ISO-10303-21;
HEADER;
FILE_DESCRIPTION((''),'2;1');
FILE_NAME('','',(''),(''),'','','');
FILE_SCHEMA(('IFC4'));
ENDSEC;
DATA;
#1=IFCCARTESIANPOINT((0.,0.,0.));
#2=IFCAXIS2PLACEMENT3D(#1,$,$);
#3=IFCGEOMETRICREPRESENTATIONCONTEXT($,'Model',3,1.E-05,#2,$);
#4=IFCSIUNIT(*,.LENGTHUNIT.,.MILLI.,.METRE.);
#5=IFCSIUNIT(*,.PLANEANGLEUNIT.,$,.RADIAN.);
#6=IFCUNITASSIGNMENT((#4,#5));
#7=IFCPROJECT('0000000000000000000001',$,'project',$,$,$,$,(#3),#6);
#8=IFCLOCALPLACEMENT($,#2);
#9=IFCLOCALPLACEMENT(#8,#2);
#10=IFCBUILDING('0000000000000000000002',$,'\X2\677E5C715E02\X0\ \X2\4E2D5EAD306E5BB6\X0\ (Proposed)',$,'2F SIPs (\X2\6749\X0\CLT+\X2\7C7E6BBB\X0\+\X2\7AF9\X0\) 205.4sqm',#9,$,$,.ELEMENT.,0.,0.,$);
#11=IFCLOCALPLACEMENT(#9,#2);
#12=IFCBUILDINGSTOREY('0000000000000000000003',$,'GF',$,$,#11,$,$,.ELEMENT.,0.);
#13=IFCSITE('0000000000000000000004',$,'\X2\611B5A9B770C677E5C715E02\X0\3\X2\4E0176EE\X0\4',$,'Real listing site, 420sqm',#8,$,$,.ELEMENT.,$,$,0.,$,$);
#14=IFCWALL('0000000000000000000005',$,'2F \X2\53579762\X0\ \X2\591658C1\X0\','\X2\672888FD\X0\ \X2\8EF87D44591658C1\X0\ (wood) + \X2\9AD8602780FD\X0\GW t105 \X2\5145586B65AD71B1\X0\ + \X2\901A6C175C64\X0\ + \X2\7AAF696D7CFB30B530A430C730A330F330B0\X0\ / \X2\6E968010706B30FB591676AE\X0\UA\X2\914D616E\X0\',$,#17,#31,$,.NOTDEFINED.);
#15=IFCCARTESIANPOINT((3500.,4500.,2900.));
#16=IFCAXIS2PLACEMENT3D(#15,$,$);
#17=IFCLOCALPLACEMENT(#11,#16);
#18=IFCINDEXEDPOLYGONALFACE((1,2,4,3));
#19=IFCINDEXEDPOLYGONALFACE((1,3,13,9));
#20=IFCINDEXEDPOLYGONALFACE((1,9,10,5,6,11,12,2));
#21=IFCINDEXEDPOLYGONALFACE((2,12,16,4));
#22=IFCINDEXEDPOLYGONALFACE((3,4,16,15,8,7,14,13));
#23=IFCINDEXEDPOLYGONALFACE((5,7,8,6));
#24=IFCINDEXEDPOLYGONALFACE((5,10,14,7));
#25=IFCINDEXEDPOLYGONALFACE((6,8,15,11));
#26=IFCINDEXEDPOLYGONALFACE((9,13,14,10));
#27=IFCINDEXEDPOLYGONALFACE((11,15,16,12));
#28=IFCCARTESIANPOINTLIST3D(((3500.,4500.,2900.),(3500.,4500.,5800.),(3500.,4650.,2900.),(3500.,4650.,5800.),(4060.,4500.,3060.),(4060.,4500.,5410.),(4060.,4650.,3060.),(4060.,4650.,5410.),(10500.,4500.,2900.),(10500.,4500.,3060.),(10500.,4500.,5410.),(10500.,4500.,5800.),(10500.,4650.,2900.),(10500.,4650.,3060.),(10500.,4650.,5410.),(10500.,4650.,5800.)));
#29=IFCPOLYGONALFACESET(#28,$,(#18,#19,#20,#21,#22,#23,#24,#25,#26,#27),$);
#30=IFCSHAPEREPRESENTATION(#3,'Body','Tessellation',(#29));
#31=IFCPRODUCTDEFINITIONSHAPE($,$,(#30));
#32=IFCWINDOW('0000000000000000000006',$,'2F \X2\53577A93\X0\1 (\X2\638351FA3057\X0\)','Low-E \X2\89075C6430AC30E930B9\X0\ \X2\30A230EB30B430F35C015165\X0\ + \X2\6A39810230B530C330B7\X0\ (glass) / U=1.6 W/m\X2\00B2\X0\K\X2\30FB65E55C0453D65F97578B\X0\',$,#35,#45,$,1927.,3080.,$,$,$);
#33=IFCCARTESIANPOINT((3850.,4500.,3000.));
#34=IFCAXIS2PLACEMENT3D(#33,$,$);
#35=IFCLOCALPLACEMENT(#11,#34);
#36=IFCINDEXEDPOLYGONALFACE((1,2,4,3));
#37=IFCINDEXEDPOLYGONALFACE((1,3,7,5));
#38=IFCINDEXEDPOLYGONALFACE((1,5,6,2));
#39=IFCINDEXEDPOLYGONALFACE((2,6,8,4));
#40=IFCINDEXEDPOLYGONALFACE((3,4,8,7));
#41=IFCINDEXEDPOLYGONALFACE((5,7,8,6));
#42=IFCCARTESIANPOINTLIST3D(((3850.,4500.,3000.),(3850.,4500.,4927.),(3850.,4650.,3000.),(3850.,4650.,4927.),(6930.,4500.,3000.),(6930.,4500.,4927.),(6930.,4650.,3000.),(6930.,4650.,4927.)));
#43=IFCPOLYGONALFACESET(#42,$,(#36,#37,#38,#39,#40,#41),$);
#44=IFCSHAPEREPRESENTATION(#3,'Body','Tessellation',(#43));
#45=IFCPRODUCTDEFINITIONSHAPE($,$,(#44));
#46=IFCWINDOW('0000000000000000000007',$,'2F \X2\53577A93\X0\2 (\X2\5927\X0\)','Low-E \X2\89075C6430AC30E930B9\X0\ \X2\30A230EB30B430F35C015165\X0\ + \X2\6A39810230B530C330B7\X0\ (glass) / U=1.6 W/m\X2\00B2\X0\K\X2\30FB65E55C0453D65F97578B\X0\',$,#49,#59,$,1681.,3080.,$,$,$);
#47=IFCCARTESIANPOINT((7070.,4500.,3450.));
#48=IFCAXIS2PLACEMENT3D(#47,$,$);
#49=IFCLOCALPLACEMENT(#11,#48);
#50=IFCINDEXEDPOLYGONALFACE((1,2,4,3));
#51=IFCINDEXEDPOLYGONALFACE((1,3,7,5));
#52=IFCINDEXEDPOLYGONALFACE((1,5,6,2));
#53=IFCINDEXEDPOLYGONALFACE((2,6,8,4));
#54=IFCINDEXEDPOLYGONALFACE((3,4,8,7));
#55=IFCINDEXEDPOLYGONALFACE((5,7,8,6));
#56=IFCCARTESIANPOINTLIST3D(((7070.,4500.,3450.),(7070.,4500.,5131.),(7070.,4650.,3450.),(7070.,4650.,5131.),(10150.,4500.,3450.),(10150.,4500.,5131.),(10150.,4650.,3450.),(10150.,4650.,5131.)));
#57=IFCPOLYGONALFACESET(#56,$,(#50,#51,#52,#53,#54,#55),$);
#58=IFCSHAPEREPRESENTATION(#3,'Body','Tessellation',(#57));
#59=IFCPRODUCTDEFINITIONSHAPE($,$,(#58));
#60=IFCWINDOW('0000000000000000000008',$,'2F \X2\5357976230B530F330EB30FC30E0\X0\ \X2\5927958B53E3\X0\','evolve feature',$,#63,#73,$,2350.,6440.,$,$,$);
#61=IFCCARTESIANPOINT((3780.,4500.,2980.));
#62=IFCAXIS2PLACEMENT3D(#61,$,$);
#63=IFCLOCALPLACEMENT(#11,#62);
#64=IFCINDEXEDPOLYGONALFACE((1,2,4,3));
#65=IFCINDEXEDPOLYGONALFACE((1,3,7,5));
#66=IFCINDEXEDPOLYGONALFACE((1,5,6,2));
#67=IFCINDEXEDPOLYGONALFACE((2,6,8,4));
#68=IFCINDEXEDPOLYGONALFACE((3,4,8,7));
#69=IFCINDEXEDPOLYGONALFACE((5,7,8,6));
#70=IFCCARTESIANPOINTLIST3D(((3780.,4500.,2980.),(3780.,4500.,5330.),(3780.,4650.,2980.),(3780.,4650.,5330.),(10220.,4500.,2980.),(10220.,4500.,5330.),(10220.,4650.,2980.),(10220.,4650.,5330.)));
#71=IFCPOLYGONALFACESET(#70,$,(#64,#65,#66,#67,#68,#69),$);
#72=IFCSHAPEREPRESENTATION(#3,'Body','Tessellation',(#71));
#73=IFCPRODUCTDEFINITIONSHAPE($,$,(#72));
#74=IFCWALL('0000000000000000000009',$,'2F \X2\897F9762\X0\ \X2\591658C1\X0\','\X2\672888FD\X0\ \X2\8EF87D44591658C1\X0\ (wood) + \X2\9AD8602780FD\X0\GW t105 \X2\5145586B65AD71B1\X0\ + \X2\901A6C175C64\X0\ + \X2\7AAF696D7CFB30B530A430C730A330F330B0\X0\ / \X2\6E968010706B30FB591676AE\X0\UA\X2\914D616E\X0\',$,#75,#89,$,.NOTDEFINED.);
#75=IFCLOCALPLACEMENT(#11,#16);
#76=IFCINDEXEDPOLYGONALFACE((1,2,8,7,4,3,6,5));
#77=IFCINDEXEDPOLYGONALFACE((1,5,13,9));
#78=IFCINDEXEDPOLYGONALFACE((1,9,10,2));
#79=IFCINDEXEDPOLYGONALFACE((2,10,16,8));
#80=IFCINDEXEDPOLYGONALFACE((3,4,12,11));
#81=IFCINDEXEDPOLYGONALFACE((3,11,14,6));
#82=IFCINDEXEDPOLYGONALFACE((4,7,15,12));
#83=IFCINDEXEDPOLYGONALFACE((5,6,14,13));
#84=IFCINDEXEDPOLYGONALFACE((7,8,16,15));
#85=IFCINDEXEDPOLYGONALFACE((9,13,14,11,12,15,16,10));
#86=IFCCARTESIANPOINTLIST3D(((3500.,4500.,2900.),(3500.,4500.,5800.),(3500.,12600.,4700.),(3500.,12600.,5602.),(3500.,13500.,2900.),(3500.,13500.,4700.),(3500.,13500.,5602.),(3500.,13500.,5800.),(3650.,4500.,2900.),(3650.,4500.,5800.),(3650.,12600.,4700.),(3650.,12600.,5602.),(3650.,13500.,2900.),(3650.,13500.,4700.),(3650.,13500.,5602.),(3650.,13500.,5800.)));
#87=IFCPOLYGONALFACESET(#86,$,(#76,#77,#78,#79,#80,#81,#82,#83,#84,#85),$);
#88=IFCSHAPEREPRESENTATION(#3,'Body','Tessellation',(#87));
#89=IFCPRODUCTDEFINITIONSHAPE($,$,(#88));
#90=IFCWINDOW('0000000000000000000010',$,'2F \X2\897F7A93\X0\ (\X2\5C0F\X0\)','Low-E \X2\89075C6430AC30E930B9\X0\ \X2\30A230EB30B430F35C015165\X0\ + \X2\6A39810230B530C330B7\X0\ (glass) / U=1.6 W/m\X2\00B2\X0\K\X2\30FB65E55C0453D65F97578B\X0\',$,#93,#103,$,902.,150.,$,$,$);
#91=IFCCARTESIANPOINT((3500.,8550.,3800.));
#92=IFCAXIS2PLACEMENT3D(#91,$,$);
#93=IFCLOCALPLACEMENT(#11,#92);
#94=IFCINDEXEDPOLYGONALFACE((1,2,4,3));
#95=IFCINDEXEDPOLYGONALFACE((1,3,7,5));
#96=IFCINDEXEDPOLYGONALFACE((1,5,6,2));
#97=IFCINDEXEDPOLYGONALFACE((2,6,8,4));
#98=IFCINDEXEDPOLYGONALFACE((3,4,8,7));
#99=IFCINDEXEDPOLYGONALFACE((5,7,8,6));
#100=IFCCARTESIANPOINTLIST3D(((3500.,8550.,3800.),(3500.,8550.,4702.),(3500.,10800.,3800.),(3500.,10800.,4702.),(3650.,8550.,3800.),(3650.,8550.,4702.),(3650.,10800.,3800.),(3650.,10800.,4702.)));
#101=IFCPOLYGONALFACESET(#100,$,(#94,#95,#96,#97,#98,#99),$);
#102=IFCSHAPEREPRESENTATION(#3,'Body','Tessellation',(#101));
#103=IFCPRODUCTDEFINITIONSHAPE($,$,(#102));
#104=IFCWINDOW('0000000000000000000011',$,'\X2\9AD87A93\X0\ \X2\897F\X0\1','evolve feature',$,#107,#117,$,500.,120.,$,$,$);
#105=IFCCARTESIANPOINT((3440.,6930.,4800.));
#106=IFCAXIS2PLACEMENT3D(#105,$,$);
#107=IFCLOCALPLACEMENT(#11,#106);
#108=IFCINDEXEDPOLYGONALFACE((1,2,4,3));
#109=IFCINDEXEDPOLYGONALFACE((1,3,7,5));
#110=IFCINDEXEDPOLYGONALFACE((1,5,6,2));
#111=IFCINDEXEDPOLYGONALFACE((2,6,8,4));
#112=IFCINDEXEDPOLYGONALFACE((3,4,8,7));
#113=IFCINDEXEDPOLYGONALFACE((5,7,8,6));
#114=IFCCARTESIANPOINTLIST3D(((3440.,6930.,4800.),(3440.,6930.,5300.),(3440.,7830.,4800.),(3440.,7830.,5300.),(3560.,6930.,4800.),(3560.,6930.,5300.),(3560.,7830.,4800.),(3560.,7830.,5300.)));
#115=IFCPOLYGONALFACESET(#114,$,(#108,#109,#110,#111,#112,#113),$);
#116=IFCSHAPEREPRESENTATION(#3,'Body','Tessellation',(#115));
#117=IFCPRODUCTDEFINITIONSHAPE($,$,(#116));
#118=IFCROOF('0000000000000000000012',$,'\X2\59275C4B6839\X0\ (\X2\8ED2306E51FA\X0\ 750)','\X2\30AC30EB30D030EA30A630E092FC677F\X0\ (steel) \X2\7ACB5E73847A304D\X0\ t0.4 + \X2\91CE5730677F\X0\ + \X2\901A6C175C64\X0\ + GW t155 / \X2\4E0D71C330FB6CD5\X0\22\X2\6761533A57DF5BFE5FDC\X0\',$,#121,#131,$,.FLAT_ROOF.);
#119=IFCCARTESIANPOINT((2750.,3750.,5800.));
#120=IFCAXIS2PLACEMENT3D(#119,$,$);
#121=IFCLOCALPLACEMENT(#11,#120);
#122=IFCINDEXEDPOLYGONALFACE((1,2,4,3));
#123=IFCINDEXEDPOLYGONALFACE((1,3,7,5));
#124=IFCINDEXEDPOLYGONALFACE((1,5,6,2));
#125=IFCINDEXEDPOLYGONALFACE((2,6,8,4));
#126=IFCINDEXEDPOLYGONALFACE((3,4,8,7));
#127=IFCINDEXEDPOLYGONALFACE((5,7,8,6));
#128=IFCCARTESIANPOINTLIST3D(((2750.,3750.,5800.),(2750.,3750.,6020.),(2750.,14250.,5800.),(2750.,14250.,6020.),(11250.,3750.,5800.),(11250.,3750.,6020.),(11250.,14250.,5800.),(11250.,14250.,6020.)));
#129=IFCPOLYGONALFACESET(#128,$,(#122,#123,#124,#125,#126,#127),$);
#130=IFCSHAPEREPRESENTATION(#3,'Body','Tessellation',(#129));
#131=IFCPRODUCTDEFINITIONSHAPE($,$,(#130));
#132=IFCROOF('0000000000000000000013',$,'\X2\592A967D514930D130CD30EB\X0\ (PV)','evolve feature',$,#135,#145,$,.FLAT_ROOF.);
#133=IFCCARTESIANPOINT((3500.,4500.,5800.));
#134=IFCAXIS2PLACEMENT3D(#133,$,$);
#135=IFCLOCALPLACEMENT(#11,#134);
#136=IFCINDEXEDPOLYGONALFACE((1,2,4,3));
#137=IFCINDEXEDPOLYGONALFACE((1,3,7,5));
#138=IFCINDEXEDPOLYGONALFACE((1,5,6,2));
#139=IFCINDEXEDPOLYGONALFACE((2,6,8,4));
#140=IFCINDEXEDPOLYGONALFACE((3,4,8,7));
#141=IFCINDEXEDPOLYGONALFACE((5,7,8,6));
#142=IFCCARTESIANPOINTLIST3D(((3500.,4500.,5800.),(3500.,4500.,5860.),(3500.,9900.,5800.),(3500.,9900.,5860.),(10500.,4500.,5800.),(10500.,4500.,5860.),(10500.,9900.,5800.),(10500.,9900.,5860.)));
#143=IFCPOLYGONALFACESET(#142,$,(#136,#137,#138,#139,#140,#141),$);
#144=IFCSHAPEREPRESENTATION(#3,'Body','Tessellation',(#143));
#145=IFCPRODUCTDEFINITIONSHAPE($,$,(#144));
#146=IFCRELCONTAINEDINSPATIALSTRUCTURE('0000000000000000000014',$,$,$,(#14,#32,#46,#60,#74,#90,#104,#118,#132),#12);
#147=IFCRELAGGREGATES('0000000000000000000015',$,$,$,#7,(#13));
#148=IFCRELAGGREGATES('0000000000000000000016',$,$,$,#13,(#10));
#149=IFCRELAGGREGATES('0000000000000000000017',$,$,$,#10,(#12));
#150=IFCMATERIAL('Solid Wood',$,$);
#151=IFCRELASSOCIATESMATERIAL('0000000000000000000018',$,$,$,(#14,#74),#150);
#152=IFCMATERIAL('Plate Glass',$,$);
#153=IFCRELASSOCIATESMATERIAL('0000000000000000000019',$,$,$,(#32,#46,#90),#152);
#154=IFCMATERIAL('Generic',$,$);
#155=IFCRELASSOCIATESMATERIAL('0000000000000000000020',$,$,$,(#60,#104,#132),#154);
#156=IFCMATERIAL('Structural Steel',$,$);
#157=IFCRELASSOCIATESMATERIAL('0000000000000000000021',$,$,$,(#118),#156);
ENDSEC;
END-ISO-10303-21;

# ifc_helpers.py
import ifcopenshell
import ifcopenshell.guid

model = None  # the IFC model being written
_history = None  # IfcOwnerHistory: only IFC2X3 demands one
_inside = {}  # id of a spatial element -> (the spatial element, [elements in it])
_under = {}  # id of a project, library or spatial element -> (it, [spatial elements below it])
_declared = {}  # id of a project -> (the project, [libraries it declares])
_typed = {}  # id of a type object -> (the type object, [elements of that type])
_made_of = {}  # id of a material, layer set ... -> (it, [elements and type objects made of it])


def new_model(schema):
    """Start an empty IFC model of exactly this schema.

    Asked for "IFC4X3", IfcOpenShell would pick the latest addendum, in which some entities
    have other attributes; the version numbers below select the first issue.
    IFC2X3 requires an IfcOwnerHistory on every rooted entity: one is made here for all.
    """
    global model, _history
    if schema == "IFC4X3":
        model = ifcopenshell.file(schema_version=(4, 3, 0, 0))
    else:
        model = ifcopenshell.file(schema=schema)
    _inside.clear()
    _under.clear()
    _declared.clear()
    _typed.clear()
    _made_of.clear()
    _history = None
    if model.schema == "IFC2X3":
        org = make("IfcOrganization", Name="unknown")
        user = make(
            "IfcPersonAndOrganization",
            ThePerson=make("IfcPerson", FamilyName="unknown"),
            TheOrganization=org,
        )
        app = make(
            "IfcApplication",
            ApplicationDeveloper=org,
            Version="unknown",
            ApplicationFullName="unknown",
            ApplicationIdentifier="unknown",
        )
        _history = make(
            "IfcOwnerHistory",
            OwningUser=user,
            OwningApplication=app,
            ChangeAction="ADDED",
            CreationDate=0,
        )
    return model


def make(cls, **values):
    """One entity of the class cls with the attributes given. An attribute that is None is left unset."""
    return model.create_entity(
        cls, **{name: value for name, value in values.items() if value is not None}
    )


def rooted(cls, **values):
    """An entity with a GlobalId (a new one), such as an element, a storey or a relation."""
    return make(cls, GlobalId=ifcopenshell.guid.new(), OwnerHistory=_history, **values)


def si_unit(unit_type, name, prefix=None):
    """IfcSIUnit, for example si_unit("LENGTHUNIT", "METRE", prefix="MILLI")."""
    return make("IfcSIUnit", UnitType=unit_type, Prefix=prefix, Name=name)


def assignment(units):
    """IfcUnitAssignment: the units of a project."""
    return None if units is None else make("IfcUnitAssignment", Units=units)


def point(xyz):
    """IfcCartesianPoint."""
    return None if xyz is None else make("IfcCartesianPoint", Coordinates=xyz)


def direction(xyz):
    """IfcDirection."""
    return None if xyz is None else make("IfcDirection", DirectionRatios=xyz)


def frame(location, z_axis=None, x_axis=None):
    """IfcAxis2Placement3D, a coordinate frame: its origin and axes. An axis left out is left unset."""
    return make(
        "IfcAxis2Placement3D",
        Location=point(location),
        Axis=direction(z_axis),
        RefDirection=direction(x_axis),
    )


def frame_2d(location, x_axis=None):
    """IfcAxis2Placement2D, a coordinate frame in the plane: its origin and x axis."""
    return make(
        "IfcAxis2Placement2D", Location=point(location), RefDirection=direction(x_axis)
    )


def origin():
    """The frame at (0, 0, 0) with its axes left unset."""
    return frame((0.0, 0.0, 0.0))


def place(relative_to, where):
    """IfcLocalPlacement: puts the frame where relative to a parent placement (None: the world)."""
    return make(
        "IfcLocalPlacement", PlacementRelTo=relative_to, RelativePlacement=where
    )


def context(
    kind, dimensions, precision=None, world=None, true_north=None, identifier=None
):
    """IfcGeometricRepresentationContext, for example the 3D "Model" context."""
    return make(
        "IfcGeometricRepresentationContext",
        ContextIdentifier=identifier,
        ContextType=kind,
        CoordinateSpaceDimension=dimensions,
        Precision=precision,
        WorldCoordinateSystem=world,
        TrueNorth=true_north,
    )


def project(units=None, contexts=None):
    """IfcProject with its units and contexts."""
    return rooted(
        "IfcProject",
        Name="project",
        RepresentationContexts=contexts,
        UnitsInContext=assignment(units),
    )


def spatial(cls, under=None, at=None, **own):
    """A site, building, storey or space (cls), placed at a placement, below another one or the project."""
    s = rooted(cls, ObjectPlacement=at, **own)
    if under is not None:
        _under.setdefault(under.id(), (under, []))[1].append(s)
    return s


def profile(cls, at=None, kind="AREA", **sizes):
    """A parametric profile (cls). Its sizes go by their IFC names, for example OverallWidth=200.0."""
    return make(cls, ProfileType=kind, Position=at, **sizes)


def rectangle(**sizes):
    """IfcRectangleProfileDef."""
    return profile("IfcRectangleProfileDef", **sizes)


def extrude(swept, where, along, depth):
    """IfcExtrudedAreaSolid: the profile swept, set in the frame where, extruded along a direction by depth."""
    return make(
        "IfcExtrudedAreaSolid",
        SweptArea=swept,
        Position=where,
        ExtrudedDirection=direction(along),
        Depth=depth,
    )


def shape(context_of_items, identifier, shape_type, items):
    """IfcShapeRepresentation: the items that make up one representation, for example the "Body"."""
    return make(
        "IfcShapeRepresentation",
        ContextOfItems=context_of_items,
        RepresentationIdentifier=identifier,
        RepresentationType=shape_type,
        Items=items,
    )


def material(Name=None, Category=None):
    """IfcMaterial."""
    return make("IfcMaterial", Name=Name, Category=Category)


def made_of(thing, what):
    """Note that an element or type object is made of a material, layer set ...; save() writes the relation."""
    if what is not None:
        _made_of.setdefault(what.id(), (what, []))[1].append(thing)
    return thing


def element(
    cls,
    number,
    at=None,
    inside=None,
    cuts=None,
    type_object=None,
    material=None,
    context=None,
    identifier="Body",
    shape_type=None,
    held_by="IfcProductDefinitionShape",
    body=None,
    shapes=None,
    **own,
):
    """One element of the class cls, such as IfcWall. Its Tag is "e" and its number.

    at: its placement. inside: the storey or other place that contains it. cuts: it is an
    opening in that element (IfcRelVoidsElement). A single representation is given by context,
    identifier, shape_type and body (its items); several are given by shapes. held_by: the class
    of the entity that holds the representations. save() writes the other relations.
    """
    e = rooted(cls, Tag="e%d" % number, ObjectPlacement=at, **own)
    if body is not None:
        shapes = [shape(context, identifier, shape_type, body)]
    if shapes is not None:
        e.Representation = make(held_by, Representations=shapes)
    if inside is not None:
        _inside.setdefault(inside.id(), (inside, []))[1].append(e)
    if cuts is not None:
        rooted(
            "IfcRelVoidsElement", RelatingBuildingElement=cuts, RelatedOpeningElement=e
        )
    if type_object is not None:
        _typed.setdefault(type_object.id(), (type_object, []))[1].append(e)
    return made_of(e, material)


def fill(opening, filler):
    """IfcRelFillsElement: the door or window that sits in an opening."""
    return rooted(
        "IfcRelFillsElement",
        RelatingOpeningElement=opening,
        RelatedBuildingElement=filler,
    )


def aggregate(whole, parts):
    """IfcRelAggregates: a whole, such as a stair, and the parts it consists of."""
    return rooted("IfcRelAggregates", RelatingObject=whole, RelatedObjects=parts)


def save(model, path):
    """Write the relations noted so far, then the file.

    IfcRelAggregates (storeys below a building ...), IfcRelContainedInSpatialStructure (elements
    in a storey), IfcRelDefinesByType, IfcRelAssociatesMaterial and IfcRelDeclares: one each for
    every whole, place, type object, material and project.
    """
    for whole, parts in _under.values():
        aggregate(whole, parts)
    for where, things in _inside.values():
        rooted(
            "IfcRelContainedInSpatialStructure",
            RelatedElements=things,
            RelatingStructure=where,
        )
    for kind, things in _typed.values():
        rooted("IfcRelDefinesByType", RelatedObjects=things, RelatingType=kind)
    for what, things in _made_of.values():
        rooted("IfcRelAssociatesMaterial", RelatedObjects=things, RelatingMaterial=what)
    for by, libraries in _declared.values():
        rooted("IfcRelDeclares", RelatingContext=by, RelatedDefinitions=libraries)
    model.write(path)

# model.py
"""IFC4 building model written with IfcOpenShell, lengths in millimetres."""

from ifc_helpers import new_model, si_unit, frame, frame_2d, origin, place, context, project, spatial, rectangle, extrude, material, element, fill, save


model = new_model("IFC4")

# Units and contexts
model_context = context("Model", 3, precision=1e-05, world=origin())
ifc_project = project(units=[si_unit("LENGTHUNIT", "METRE", prefix="MILLI"), si_unit("PLANEANGLEUNIT", "RADIAN")], contexts=[model_context])

# Site, building, storey
site_placement = place(None, origin())
site = spatial("IfcSite", under=ifc_project, at=site_placement, Name="愛媛県松山市3丁目4", ObjectType="Real listing site, 420sqm", CompositionType="ELEMENT", RefElevation=0.0)
building_placement = place(site_placement, origin())
building = spatial("IfcBuilding", under=site, at=building_placement, Name="松山市 中庭の家 (Proposed)", ObjectType="2F SIPs (杉CLT+籾殻+竹) 205.4sqm", CompositionType="ELEMENT", ElevationOfRefHeight=0.0, ElevationOfTerrain=0.0)
storey_placement = place(building_placement, origin())
storey = spatial("IfcBuildingStorey", under=building, at=storey_placement, Name="GF", CompositionType="ELEMENT", Elevation=0.0)

# Shared definitions
ifc_material_1 = material(Name="Solid Wood")
ifc_material_2 = material(Name="Generic")

# Shared definitions
ifc_material_3 = material(Name="Plate Glass")

# Walls, openings, windows
wall_1_placement = place(storey_placement, frame((3500.0, 4500.0, 2900.0)))
wall_1 = element("IfcWall", 1, at=wall_1_placement, inside=storey, material=ifc_material_1, Name="2F 南面 外壁", Description="木製 軸組外壁 (wood) + 高性能GW t105 充填断熱 + 通気層 + 窯業系サイディング / 準耐火・外皮UA配慮", PredefinedType="NOTDEFINED", context=model_context, shape_type="SweptSolid", body=[
    extrude(rectangle(XDim=7000.0, YDim=150.0, at=frame_2d((3500.0, 75.0))), frame((3500.0, 4500.0, 2900.0)), (0.0, 0.0, 1.0), 2900.0),
])
opening_1_placement = place(storey_placement, frame((3850.0, 4500.0, 3000.0)))
opening_1 = element("IfcOpeningElement", 2, at=opening_1_placement, cuts=wall_1, PredefinedType="NOTDEFINED", context=model_context, shape_type="SweptSolid", body=[
    extrude(rectangle(XDim=3080.0, YDim=150.0, at=frame_2d((1540.0, 75.0))), frame((3850.0, 4500.0, 3000.0)), (0.0, 0.0, 1.0), 1927.0),
])
opening_2_placement = place(storey_placement, frame((7070.0, 4500.0, 3450.0)))
opening_2 = element("IfcOpeningElement", 3, at=opening_2_placement, cuts=wall_1, PredefinedType="NOTDEFINED", context=model_context, shape_type="SweptSolid", body=[
    extrude(rectangle(XDim=3080.0, YDim=150.0, at=frame_2d((1540.0, 75.0))), frame((7070.0, 4500.0, 3450.0)), (0.0, 0.0, 1.0), 1681.0),
])
opening_3_placement = place(storey_placement, frame((3780.0, 4500.0, 2980.0)))
opening_3 = element("IfcOpeningElement", 4, at=opening_3_placement, cuts=wall_1, PredefinedType="NOTDEFINED", context=model_context, shape_type="SweptSolid", body=[
    extrude(rectangle(XDim=6440.0, YDim=150.0, at=frame_2d((3220.0, 75.0))), frame((3780.0, 4500.0, 2980.0)), (0.0, 0.0, 1.0), 2350.0),
])
window_1_placement = place(storey_placement, frame((3850.0, 4500.0, 3000.0)))
window_1 = element("IfcWindow", 5, at=window_1_placement, inside=storey, material=ifc_material_3, Name="2F 南窓1 (掃出し)", Description="Low-E 複層ガラス アルゴン封入 + 樹脂サッシ (glass) / U=1.6 W/m²K・日射取得型", OverallHeight=1927.0, OverallWidth=3080.0, context=model_context, shape_type="SweptSolid", body=[
    extrude(rectangle(XDim=3080.0, YDim=150.0, at=frame_2d((1540.0, 75.0))), frame((3850.0, 4500.0, 3000.0)), (0.0, 0.0, 1.0), 1927.0),
])
fill(opening_1, window_1)
window_2_placement = place(storey_placement, frame((7070.0, 4500.0, 3450.0)))
window_2 = element("IfcWindow", 6, at=window_2_placement, inside=storey, material=ifc_material_3, Name="2F 南窓2 (大)", Description="Low-E 複層ガラス アルゴン封入 + 樹脂サッシ (glass) / U=1.6 W/m²K・日射取得型", OverallHeight=1681.0, OverallWidth=3080.0, context=model_context, shape_type="SweptSolid", body=[
    extrude(rectangle(XDim=3080.0, YDim=150.0, at=frame_2d((1540.0, 75.0))), frame((7070.0, 4500.0, 3450.0)), (0.0, 0.0, 1.0), 1681.0),
])
fill(opening_2, window_2)
window_3_placement = place(storey_placement, frame((3780.0, 4500.0, 2980.0)))
window_3 = element("IfcWindow", 7, at=window_3_placement, inside=storey, material=ifc_material_2, Name="2F 南面サンルーム 大開口", Description="evolve feature", OverallHeight=2350.0, OverallWidth=6440.0, context=model_context, shape_type="SweptSolid", body=[
    extrude(rectangle(XDim=6440.0, YDim=150.0, at=frame_2d((3220.0, 75.0))), frame((3780.0, 4500.0, 2980.0)), (0.0, 0.0, 1.0), 2350.0),
])
fill(opening_3, window_3)
wall_2_placement = place(storey_placement, frame((3500.0, 4500.0, 2900.0)))
wall_2 = element("IfcWall", 8, at=wall_2_placement, inside=storey, material=ifc_material_1, Name="2F 西面 外壁", Description="木製 軸組外壁 (wood) + 高性能GW t105 充填断熱 + 通気層 + 窯業系サイディング / 準耐火・外皮UA配慮", PredefinedType="NOTDEFINED", context=model_context, shape_type="SweptSolid", body=[
    extrude(rectangle(XDim=150.0, YDim=9000.0, at=frame_2d((75.0, 4500.0))), frame((3500.0, 4500.0, 2900.0)), (0.0, 0.0, 1.0), 2900.0),
])
opening_4_placement = place(storey_placement, frame((3500.0, 8550.0, 3800.0)))
opening_4 = element("IfcOpeningElement", 9, at=opening_4_placement, cuts=wall_2, PredefinedType="NOTDEFINED", context=model_context, shape_type="SweptSolid", body=[
    extrude(rectangle(XDim=150.0, YDim=2250.0, at=frame_2d((75.0, 1125.0))), frame((3500.0, 8550.0, 3800.0)), (0.0, 0.0, 1.0), 902.0),
])
opening_5_placement = place(storey_placement, frame((3440.0, 6930.0, 4800.0)))
opening_5 = element("IfcOpeningElement", 10, at=opening_5_placement, cuts=wall_2, PredefinedType="NOTDEFINED", context=model_context, shape_type="SweptSolid", body=[
    extrude(rectangle(XDim=120.0, YDim=900.0, at=frame_2d((60.0, 450.0))), frame((3440.0, 6930.0, 4800.0)), (0.0, 0.0, 1.0), 500.0),
])
window_4_placement = place(storey_placement, frame((3500.0, 8550.0, 3800.0)))
window_4 = element("IfcWindow", 11, at=window_4_placement, inside=storey, material=ifc_material_3, Name="2F 西窓 (小)", Description="Low-E 複層ガラス アルゴン封入 + 樹脂サッシ (glass) / U=1.6 W/m²K・日射取得型", OverallHeight=902.0, OverallWidth=150.0, context=model_context, shape_type="SweptSolid", body=[
    extrude(rectangle(XDim=150.0, YDim=2250.0, at=frame_2d((75.0, 1125.0))), frame((3500.0, 8550.0, 3800.0)), (0.0, 0.0, 1.0), 902.0),
])
fill(opening_4, window_4)
window_5_placement = place(storey_placement, frame((3440.0, 6930.0, 4800.0)))
window_5 = element("IfcWindow", 12, at=window_5_placement, inside=storey, material=ifc_material_2, Name="高窓 西1", Description="evolve feature", OverallHeight=500.0, OverallWidth=120.0, context=model_context, shape_type="SweptSolid", body=[
    extrude(rectangle(XDim=120.0, YDim=900.0, at=frame_2d((60.0, 450.0))), frame((3440.0, 6930.0, 4800.0)), (0.0, 0.0, 1.0), 500.0),
])
fill(opening_5, window_5)

# Roofs
ifc_material_4 = material(Name="Structural Steel")
roof_1_placement = place(storey_placement, frame((2750.0, 3750.0, 5800.0)))
element("IfcRoof", 13, at=roof_1_placement, inside=storey, material=ifc_material_4, Name="大屋根 (軒の出 750)", Description="ガルバリウム鋼板 (steel) 立平葺き t0.4 + 野地板 + 通気層 + GW t155 / 不燃・法22条区域対応", PredefinedType="FLAT_ROOF", context=model_context, shape_type="SweptSolid", body=[
    extrude(rectangle(XDim=8500.0, YDim=10500.0, at=frame_2d((4250.0, 5250.0))), frame((2750.0, 3750.0, 5800.0)), (0.0, 0.0, 1.0), 220.0),
])
roof_2_placement = place(storey_placement, frame((3500.0, 4500.0, 5800.0)))
element("IfcRoof", 14, at=roof_2_placement, inside=storey, material=ifc_material_2, Name="太陽光パネル (PV)", Description="evolve feature", PredefinedType="FLAT_ROOF", context=model_context, shape_type="SweptSolid", body=[
    extrude(rectangle(XDim=7000.0, YDim=5400.0, at=frame_2d((3500.0, 2700.0))), frame((3500.0, 4500.0, 5800.0)), (0.0, 0.0, 1.0), 60.0),
])

save(model, "model.ifc")
